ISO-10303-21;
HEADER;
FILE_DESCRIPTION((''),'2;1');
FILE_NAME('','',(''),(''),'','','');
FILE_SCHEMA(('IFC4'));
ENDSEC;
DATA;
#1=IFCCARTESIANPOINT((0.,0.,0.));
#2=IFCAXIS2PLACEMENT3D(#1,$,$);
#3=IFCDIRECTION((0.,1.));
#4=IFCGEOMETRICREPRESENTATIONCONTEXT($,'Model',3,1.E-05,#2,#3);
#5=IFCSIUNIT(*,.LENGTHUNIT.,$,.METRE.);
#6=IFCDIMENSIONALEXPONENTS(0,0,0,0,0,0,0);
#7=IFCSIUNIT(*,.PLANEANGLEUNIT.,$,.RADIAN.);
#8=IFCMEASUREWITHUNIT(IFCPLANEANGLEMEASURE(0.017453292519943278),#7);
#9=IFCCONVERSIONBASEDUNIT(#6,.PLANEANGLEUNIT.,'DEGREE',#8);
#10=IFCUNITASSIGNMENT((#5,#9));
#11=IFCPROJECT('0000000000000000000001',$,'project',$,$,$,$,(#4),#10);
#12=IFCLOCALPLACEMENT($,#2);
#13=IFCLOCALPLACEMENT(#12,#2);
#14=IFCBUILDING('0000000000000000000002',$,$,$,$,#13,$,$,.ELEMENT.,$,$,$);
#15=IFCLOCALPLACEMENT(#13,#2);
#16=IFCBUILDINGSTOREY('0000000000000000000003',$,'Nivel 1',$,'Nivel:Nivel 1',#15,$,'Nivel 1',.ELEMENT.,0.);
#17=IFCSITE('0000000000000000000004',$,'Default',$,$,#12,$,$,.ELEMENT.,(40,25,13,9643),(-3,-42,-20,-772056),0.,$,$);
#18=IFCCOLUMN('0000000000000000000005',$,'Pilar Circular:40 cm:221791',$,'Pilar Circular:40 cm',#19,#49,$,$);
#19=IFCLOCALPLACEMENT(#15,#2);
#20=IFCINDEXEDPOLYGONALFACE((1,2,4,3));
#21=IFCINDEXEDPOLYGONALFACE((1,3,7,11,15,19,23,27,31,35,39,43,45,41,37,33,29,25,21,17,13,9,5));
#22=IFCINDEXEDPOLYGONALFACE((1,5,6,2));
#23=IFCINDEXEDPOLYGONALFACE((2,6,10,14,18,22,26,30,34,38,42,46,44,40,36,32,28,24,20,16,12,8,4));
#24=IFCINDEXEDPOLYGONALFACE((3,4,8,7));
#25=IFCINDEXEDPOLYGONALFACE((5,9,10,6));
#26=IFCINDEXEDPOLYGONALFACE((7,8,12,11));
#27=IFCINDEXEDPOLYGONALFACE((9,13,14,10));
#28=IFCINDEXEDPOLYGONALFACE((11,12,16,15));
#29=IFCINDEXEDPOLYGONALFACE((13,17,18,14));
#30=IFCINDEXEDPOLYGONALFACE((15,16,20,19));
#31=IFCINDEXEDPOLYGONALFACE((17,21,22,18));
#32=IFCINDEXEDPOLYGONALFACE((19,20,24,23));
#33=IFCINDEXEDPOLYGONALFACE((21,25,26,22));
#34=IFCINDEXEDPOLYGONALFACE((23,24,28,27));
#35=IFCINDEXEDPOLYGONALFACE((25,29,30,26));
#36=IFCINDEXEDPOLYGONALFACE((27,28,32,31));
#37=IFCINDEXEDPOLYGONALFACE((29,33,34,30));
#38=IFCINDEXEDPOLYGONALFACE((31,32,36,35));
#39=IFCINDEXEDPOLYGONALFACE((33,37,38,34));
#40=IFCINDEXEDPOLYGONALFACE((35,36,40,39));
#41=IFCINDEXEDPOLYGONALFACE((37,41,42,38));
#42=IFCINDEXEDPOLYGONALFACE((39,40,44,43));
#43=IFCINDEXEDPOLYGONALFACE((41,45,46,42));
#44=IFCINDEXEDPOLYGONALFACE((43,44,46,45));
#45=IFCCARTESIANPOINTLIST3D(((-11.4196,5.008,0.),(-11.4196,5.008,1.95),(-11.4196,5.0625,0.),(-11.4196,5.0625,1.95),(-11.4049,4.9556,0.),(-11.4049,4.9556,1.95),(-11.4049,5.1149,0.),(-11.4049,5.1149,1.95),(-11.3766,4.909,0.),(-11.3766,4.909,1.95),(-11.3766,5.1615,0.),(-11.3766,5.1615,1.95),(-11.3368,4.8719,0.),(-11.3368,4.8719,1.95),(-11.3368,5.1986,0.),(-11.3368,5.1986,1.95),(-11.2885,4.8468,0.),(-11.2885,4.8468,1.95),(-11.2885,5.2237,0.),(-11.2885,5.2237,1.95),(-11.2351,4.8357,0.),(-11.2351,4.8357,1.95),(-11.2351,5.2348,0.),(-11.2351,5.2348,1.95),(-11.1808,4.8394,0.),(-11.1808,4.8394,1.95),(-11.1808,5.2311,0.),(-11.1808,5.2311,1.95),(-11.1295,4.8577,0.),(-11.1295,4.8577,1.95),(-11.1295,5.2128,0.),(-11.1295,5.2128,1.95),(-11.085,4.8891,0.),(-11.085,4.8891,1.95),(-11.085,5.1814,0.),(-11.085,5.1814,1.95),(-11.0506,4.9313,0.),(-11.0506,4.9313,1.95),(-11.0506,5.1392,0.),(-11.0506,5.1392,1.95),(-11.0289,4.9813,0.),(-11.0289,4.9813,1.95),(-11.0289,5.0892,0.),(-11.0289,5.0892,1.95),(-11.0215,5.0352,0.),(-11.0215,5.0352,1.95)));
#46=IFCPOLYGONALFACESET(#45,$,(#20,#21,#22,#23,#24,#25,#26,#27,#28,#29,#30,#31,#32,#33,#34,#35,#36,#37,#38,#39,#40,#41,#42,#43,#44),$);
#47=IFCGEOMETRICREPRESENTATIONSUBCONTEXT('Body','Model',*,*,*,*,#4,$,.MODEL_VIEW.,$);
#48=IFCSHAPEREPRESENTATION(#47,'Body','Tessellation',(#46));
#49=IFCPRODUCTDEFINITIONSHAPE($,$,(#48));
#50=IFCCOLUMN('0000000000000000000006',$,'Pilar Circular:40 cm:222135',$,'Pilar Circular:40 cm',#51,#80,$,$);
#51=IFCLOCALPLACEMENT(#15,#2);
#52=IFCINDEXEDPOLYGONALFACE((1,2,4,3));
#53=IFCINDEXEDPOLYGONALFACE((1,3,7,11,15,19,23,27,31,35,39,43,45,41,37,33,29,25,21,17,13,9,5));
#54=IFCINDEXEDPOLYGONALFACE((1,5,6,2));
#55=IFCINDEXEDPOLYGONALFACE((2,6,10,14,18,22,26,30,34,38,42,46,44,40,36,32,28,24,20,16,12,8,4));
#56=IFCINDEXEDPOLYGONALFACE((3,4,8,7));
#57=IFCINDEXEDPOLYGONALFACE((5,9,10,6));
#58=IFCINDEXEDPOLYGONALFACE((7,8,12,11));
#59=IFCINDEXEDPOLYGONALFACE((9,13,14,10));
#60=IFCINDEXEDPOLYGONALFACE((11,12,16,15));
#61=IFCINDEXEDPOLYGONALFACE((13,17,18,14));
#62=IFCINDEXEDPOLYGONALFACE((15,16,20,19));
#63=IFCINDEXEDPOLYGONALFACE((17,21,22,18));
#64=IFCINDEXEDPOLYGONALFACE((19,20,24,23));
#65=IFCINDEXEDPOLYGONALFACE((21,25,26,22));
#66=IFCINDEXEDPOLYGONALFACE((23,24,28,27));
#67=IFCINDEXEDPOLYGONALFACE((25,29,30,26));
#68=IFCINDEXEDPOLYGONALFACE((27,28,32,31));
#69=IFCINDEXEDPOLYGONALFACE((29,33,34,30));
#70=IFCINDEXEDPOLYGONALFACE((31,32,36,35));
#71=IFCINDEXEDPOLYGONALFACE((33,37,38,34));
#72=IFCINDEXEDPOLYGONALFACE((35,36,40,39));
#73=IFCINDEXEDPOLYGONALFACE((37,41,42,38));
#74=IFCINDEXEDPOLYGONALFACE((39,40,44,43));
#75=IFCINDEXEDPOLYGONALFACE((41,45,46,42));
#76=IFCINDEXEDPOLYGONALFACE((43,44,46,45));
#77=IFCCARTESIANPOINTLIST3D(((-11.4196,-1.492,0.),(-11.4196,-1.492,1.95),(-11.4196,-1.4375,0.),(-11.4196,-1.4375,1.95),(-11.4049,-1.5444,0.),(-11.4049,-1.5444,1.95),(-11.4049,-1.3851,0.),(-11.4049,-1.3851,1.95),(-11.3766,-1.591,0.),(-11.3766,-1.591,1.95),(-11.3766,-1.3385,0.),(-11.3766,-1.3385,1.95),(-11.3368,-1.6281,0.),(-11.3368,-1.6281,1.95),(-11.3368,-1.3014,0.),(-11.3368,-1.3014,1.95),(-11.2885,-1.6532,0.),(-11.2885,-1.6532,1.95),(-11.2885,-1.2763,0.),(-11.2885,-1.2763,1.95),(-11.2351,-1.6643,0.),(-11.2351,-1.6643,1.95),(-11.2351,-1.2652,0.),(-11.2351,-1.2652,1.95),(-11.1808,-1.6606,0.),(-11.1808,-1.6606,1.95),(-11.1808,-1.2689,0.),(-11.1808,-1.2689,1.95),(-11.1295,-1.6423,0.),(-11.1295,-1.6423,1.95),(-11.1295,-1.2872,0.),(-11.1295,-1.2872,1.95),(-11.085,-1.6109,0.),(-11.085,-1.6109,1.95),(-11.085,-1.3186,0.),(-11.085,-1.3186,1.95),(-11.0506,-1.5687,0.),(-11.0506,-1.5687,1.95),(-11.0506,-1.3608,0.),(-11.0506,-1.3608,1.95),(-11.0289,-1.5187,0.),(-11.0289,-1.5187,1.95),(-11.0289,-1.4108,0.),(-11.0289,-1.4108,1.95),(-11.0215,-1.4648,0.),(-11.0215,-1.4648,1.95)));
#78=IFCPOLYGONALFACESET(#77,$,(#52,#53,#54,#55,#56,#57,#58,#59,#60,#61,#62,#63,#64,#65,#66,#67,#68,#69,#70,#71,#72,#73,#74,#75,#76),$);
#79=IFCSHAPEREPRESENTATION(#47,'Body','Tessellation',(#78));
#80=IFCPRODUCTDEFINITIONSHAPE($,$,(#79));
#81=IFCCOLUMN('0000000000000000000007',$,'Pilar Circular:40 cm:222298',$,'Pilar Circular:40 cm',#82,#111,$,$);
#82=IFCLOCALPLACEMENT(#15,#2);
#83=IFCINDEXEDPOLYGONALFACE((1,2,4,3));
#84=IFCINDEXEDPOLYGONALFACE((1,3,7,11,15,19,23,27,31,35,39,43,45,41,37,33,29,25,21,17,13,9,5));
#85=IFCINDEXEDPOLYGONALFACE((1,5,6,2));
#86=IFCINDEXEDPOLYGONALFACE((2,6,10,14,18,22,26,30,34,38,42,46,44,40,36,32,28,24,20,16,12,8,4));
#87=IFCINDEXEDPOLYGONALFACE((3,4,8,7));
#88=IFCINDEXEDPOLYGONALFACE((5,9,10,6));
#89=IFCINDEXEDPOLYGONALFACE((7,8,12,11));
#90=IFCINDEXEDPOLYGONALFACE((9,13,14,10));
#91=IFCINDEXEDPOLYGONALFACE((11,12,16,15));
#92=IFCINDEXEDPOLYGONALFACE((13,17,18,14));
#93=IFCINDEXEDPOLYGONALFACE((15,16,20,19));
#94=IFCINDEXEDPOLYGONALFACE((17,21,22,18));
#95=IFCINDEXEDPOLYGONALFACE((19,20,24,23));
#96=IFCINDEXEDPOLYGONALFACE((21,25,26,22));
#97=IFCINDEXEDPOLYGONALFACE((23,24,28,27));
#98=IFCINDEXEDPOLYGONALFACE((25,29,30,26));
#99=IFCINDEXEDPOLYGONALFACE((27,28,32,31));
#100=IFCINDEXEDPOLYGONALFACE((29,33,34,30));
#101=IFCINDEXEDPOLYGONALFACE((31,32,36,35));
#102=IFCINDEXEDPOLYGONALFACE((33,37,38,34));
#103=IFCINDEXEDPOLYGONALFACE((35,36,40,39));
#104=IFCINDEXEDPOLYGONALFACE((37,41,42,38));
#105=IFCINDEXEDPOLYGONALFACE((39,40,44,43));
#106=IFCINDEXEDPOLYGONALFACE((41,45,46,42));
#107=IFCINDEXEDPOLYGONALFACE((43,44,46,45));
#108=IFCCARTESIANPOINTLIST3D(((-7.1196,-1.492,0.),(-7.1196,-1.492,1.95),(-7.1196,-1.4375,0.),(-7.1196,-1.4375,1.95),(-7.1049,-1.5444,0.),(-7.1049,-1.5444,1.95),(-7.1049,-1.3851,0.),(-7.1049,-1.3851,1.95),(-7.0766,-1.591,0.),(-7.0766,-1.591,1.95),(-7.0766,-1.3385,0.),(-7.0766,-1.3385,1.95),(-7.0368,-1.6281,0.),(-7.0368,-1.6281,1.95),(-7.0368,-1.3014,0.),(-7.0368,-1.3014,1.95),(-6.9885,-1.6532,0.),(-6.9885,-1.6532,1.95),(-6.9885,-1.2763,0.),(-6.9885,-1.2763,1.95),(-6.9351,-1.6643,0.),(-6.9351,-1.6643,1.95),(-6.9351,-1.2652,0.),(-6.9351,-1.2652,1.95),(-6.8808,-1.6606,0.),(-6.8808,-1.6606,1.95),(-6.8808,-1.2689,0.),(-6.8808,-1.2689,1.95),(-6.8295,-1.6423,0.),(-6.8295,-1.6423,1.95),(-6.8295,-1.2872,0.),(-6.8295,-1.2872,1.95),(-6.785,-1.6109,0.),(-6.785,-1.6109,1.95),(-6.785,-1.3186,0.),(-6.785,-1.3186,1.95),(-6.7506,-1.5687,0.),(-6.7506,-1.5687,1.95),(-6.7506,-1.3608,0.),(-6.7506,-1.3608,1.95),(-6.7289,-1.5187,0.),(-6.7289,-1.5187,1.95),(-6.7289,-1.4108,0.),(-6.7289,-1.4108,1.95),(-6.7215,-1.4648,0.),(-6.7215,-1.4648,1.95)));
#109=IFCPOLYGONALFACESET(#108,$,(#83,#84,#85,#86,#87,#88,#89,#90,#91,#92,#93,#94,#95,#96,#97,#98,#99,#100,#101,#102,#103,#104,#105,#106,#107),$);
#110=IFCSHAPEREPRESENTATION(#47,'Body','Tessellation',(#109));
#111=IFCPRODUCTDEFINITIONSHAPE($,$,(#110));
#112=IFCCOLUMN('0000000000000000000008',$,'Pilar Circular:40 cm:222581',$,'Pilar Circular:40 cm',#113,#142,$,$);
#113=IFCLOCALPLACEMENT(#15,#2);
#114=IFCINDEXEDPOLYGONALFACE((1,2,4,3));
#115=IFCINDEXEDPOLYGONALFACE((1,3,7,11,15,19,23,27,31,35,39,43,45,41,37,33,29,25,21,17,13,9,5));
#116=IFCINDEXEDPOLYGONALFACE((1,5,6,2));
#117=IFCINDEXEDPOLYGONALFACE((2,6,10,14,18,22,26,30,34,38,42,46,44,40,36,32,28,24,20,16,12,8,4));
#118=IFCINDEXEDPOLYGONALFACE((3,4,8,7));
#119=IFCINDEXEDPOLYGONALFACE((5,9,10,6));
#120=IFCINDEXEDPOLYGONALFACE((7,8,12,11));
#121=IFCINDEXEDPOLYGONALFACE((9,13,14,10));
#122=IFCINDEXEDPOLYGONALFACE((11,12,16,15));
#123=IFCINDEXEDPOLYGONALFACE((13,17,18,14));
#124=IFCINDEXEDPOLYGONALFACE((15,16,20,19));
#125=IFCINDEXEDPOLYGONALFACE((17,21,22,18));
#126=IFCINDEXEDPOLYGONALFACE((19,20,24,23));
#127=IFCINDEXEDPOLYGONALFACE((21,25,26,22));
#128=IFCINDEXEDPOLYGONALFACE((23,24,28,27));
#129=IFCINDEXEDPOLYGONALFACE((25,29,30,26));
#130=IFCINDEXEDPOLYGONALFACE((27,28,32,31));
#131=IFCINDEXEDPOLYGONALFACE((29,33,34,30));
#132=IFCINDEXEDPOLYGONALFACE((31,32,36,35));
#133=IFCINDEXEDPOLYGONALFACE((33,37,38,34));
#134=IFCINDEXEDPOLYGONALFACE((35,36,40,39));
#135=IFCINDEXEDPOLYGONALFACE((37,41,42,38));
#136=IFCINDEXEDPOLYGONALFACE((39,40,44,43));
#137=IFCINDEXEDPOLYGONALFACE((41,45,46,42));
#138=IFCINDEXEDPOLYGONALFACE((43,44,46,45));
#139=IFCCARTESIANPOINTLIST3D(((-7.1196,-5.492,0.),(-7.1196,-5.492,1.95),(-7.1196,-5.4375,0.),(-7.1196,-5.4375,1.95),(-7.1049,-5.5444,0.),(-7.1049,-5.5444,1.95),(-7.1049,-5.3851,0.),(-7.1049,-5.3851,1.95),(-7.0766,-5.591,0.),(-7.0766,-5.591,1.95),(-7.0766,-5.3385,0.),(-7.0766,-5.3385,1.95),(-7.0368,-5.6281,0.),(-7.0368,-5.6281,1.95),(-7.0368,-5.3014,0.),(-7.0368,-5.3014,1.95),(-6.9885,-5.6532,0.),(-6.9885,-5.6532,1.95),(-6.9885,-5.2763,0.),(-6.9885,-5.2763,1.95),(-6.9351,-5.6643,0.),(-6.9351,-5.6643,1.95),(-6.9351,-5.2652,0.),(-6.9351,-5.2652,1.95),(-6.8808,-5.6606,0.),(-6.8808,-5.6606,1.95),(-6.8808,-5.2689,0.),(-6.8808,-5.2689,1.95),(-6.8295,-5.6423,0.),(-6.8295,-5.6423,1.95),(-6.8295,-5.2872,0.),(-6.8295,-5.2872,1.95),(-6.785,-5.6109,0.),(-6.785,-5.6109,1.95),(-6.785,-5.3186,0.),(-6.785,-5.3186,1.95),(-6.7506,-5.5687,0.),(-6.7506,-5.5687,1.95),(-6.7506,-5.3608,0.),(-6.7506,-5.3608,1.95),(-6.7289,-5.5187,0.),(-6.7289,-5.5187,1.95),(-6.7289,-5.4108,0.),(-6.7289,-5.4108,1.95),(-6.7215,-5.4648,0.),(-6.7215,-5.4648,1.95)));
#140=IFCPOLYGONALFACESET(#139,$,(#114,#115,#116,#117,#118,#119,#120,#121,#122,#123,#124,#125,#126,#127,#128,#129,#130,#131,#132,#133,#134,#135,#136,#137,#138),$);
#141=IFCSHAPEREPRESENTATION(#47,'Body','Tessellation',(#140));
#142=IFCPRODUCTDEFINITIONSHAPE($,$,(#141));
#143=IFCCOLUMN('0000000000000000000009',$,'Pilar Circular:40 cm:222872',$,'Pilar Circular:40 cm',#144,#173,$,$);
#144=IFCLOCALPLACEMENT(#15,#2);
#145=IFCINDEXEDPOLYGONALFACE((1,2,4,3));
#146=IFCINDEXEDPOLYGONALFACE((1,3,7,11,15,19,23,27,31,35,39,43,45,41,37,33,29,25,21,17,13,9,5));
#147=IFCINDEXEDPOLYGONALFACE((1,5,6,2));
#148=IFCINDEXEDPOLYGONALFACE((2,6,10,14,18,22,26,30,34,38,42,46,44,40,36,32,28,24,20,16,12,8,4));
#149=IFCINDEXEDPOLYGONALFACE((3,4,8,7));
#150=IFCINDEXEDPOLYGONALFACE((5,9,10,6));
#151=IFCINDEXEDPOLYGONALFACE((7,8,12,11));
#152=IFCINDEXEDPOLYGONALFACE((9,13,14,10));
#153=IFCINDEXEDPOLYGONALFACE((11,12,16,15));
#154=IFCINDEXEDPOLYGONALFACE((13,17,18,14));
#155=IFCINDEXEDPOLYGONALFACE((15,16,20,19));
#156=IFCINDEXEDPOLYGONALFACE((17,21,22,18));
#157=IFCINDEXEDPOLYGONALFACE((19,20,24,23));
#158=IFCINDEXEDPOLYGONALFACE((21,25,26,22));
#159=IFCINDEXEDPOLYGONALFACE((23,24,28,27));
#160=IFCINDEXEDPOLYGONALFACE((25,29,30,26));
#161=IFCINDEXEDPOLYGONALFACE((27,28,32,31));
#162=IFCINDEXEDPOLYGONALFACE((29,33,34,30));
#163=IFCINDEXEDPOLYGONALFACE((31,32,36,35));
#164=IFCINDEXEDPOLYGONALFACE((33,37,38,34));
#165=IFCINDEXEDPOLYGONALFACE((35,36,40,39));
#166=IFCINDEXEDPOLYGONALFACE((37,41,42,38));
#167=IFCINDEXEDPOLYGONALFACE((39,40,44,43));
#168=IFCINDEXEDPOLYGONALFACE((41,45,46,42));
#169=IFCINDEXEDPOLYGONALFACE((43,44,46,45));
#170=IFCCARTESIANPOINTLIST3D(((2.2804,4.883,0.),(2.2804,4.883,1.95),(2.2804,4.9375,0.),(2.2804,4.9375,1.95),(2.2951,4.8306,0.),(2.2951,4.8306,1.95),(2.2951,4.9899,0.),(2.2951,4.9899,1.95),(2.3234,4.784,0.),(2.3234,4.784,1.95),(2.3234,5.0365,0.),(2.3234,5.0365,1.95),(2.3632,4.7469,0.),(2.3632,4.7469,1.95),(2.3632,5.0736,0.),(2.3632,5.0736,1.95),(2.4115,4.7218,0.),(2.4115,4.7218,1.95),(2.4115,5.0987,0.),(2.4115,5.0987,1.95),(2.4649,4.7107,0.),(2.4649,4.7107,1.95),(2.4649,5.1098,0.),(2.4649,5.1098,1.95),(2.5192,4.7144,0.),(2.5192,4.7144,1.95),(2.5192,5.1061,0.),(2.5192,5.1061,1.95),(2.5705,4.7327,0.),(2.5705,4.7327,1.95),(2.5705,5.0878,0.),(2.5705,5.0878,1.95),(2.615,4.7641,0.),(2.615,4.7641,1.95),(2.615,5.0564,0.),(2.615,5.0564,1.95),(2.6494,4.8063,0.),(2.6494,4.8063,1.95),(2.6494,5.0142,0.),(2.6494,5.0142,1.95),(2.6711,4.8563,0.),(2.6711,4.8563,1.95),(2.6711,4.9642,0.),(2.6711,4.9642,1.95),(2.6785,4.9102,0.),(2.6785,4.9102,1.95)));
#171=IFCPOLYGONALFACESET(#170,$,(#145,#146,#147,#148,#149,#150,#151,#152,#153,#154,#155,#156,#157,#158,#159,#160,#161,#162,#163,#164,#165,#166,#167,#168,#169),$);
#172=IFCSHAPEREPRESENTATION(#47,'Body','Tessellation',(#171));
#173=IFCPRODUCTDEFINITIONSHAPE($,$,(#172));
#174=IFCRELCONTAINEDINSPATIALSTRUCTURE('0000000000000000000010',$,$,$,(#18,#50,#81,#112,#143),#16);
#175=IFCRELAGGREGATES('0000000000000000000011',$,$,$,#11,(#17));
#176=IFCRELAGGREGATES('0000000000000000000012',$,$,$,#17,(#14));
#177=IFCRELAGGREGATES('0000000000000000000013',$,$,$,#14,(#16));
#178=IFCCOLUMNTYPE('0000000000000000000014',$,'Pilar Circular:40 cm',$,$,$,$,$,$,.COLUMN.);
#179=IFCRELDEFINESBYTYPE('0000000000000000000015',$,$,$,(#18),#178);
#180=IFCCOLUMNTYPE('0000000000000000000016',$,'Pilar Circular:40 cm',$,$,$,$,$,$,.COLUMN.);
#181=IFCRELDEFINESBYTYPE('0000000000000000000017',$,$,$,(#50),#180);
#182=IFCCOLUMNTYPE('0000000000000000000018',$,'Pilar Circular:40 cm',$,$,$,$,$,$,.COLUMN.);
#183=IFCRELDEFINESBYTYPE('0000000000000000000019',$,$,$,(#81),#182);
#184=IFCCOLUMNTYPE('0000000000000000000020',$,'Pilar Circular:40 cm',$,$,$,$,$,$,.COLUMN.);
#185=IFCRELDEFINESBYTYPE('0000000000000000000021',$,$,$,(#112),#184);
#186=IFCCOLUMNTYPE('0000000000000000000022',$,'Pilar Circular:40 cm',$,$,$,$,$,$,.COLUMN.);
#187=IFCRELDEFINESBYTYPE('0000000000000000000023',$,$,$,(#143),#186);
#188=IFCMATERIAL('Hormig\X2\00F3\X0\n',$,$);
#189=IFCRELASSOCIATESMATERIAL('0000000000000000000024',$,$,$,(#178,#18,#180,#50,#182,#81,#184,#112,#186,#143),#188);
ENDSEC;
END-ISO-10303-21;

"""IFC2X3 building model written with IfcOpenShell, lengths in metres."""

from ifc_helpers import new_model, entity, si_unit, converted_unit, direction, frame, frame_2d, origin, origin_2d_with_axis, place, context, subcontext, project, spatial, circle, extrude, source, transform, mapped, material, type_object, type_shapes, element, save


model = new_model("IFC2X3")

# Units and contexts
model_context = context("Model", 3, precision=1e-05, world=origin(), true_north=direction((0.0, 1.0)))
body_context = subcontext(model_context, "Body", "Model", "MODEL_VIEW")
ifc_project = project(units=[si_unit("LENGTHUNIT", "METRE"), converted_unit("PLANEANGLEUNIT", "DEGREE", entity("IfcPlaneAngleMeasure", 0.017453292519943278), si_unit("PLANEANGLEUNIT", "RADIAN"), dimensions=[0, 0, 0, 0, 0, 0, 0])], contexts=[model_context])

# Site, building, storey
site_placement = place(None, origin())
site = spatial("IfcSite", under=ifc_project, at=site_placement, Name="Default", CompositionType="ELEMENT", RefLatitude=(40, 25, 13, 9643), RefLongitude=(-3, -42, -20, -772056), RefElevation=0.0)
building_placement = place(site_placement, origin())
building = spatial("IfcBuilding", under=site, at=building_placement, CompositionType="ELEMENT")
storey_placement = place(building_placement, origin())
storey = spatial("IfcBuildingStorey", under=building, at=storey_placement, Name="Nivel 1", ObjectType="Nivel:Nivel 1", LongName="Nivel 1", CompositionType="ELEMENT", Elevation=0.0)

# Columns
ifc_material_1 = material(Name="Hormigón")
column_type_1 = type_object("IfcColumnType", Name="Pilar Circular:40 cm", PredefinedType="COLUMN", material=ifc_material_1)
shared_shape_1 = source(origin(), body_context, "Body", "SweptSolid", [
    extrude(circle(Radius=0.2, at=frame_2d((0.0, 0.0), x_axis=(1.0, 0.0))), frame((-11.2215, 5.0352, 0.0)), (0.0, 0.0, 1.0), 1.95),
])
type_shapes(column_type_1, [shared_shape_1])
column_1_placement = place(storey_placement, origin())
element("IfcColumn", 1, at=column_1_placement, inside=storey, type_object=column_type_1, material=ifc_material_1, Name="Pilar Circular:40 cm:221791", ObjectType="Pilar Circular:40 cm", context=body_context, shape_type="MappedRepresentation", body=[
    mapped(shared_shape_1, transform((0.0, 0.0, 0.0), scale=1.0)),
])
column_type_2 = type_object("IfcColumnType", Name="Pilar Circular:40 cm", PredefinedType="COLUMN", material=ifc_material_1)
shared_shape_2 = source(origin(), body_context, "Body", "SweptSolid", [
    extrude(circle(Radius=0.2, at=frame_2d((0.0, 0.0), x_axis=(1.0, 0.0))), frame((-11.2215, -1.4648, 0.0)), (0.0, 0.0, 1.0), 1.95),
])
type_shapes(column_type_2, [shared_shape_2])
column_2_placement = place(storey_placement, origin())
element("IfcColumn", 2, at=column_2_placement, inside=storey, type_object=column_type_2, material=ifc_material_1, Name="Pilar Circular:40 cm:222135", ObjectType="Pilar Circular:40 cm", context=body_context, shape_type="MappedRepresentation", body=[
    mapped(shared_shape_2, transform((0.0, 0.0, 0.0), scale=1.0)),
])
column_type_3 = type_object("IfcColumnType", Name="Pilar Circular:40 cm", PredefinedType="COLUMN", material=ifc_material_1)
shared_shape_3 = source(origin(), body_context, "Body", "SweptSolid", [
    extrude(circle(Radius=0.2, at=frame_2d((0.0, 0.0), x_axis=(1.0, 0.0))), frame((-6.9215, -1.4648, 0.0)), (0.0, 0.0, 1.0), 1.95),
])
type_shapes(column_type_3, [shared_shape_3])
column_3_placement = place(storey_placement, origin())
element("IfcColumn", 3, at=column_3_placement, inside=storey, type_object=column_type_3, material=ifc_material_1, Name="Pilar Circular:40 cm:222298", ObjectType="Pilar Circular:40 cm", context=body_context, shape_type="MappedRepresentation", body=[
    mapped(shared_shape_3, transform((0.0, 0.0, 0.0), scale=1.0)),
])
column_type_4 = type_object("IfcColumnType", Name="Pilar Circular:40 cm", PredefinedType="COLUMN", material=ifc_material_1)
shared_shape_4 = source(origin(), body_context, "Body", "SweptSolid", [
    extrude(circle(Radius=0.2, at=origin_2d_with_axis()), frame((-6.9215, -5.4648, 0.0)), (0.0, 0.0, 1.0), 1.95),
])
type_shapes(column_type_4, [shared_shape_4])
column_4_placement = place(storey_placement, origin())
element("IfcColumn", 4, at=column_4_placement, inside=storey, type_object=column_type_4, material=ifc_material_1, Name="Pilar Circular:40 cm:222581", ObjectType="Pilar Circular:40 cm", context=body_context, shape_type="MappedRepresentation", body=[
    mapped(shared_shape_4, transform((0.0, 0.0, 0.0), scale=1.0)),
])
column_type_5 = type_object("IfcColumnType", Name="Pilar Circular:40 cm", PredefinedType="COLUMN", material=ifc_material_1)
shared_shape_5 = source(origin(), body_context, "Body", "SweptSolid", [
    extrude(circle(Radius=0.2, at=origin_2d_with_axis()), frame((2.4785, 4.9102, 0.0)), (0.0, 0.0, 1.0), 1.95),
])
type_shapes(column_type_5, [shared_shape_5])
column_5_placement = place(storey_placement, origin())
element("IfcColumn", 5, at=column_5_placement, inside=storey, type_object=column_type_5, material=ifc_material_1, Name="Pilar Circular:40 cm:222872", ObjectType="Pilar Circular:40 cm", context=body_context, shape_type="MappedRepresentation", body=[
    mapped(shared_shape_5, transform((0.0, 0.0, 0.0), scale=1.0)),
])

save(model, "model.ifc")
